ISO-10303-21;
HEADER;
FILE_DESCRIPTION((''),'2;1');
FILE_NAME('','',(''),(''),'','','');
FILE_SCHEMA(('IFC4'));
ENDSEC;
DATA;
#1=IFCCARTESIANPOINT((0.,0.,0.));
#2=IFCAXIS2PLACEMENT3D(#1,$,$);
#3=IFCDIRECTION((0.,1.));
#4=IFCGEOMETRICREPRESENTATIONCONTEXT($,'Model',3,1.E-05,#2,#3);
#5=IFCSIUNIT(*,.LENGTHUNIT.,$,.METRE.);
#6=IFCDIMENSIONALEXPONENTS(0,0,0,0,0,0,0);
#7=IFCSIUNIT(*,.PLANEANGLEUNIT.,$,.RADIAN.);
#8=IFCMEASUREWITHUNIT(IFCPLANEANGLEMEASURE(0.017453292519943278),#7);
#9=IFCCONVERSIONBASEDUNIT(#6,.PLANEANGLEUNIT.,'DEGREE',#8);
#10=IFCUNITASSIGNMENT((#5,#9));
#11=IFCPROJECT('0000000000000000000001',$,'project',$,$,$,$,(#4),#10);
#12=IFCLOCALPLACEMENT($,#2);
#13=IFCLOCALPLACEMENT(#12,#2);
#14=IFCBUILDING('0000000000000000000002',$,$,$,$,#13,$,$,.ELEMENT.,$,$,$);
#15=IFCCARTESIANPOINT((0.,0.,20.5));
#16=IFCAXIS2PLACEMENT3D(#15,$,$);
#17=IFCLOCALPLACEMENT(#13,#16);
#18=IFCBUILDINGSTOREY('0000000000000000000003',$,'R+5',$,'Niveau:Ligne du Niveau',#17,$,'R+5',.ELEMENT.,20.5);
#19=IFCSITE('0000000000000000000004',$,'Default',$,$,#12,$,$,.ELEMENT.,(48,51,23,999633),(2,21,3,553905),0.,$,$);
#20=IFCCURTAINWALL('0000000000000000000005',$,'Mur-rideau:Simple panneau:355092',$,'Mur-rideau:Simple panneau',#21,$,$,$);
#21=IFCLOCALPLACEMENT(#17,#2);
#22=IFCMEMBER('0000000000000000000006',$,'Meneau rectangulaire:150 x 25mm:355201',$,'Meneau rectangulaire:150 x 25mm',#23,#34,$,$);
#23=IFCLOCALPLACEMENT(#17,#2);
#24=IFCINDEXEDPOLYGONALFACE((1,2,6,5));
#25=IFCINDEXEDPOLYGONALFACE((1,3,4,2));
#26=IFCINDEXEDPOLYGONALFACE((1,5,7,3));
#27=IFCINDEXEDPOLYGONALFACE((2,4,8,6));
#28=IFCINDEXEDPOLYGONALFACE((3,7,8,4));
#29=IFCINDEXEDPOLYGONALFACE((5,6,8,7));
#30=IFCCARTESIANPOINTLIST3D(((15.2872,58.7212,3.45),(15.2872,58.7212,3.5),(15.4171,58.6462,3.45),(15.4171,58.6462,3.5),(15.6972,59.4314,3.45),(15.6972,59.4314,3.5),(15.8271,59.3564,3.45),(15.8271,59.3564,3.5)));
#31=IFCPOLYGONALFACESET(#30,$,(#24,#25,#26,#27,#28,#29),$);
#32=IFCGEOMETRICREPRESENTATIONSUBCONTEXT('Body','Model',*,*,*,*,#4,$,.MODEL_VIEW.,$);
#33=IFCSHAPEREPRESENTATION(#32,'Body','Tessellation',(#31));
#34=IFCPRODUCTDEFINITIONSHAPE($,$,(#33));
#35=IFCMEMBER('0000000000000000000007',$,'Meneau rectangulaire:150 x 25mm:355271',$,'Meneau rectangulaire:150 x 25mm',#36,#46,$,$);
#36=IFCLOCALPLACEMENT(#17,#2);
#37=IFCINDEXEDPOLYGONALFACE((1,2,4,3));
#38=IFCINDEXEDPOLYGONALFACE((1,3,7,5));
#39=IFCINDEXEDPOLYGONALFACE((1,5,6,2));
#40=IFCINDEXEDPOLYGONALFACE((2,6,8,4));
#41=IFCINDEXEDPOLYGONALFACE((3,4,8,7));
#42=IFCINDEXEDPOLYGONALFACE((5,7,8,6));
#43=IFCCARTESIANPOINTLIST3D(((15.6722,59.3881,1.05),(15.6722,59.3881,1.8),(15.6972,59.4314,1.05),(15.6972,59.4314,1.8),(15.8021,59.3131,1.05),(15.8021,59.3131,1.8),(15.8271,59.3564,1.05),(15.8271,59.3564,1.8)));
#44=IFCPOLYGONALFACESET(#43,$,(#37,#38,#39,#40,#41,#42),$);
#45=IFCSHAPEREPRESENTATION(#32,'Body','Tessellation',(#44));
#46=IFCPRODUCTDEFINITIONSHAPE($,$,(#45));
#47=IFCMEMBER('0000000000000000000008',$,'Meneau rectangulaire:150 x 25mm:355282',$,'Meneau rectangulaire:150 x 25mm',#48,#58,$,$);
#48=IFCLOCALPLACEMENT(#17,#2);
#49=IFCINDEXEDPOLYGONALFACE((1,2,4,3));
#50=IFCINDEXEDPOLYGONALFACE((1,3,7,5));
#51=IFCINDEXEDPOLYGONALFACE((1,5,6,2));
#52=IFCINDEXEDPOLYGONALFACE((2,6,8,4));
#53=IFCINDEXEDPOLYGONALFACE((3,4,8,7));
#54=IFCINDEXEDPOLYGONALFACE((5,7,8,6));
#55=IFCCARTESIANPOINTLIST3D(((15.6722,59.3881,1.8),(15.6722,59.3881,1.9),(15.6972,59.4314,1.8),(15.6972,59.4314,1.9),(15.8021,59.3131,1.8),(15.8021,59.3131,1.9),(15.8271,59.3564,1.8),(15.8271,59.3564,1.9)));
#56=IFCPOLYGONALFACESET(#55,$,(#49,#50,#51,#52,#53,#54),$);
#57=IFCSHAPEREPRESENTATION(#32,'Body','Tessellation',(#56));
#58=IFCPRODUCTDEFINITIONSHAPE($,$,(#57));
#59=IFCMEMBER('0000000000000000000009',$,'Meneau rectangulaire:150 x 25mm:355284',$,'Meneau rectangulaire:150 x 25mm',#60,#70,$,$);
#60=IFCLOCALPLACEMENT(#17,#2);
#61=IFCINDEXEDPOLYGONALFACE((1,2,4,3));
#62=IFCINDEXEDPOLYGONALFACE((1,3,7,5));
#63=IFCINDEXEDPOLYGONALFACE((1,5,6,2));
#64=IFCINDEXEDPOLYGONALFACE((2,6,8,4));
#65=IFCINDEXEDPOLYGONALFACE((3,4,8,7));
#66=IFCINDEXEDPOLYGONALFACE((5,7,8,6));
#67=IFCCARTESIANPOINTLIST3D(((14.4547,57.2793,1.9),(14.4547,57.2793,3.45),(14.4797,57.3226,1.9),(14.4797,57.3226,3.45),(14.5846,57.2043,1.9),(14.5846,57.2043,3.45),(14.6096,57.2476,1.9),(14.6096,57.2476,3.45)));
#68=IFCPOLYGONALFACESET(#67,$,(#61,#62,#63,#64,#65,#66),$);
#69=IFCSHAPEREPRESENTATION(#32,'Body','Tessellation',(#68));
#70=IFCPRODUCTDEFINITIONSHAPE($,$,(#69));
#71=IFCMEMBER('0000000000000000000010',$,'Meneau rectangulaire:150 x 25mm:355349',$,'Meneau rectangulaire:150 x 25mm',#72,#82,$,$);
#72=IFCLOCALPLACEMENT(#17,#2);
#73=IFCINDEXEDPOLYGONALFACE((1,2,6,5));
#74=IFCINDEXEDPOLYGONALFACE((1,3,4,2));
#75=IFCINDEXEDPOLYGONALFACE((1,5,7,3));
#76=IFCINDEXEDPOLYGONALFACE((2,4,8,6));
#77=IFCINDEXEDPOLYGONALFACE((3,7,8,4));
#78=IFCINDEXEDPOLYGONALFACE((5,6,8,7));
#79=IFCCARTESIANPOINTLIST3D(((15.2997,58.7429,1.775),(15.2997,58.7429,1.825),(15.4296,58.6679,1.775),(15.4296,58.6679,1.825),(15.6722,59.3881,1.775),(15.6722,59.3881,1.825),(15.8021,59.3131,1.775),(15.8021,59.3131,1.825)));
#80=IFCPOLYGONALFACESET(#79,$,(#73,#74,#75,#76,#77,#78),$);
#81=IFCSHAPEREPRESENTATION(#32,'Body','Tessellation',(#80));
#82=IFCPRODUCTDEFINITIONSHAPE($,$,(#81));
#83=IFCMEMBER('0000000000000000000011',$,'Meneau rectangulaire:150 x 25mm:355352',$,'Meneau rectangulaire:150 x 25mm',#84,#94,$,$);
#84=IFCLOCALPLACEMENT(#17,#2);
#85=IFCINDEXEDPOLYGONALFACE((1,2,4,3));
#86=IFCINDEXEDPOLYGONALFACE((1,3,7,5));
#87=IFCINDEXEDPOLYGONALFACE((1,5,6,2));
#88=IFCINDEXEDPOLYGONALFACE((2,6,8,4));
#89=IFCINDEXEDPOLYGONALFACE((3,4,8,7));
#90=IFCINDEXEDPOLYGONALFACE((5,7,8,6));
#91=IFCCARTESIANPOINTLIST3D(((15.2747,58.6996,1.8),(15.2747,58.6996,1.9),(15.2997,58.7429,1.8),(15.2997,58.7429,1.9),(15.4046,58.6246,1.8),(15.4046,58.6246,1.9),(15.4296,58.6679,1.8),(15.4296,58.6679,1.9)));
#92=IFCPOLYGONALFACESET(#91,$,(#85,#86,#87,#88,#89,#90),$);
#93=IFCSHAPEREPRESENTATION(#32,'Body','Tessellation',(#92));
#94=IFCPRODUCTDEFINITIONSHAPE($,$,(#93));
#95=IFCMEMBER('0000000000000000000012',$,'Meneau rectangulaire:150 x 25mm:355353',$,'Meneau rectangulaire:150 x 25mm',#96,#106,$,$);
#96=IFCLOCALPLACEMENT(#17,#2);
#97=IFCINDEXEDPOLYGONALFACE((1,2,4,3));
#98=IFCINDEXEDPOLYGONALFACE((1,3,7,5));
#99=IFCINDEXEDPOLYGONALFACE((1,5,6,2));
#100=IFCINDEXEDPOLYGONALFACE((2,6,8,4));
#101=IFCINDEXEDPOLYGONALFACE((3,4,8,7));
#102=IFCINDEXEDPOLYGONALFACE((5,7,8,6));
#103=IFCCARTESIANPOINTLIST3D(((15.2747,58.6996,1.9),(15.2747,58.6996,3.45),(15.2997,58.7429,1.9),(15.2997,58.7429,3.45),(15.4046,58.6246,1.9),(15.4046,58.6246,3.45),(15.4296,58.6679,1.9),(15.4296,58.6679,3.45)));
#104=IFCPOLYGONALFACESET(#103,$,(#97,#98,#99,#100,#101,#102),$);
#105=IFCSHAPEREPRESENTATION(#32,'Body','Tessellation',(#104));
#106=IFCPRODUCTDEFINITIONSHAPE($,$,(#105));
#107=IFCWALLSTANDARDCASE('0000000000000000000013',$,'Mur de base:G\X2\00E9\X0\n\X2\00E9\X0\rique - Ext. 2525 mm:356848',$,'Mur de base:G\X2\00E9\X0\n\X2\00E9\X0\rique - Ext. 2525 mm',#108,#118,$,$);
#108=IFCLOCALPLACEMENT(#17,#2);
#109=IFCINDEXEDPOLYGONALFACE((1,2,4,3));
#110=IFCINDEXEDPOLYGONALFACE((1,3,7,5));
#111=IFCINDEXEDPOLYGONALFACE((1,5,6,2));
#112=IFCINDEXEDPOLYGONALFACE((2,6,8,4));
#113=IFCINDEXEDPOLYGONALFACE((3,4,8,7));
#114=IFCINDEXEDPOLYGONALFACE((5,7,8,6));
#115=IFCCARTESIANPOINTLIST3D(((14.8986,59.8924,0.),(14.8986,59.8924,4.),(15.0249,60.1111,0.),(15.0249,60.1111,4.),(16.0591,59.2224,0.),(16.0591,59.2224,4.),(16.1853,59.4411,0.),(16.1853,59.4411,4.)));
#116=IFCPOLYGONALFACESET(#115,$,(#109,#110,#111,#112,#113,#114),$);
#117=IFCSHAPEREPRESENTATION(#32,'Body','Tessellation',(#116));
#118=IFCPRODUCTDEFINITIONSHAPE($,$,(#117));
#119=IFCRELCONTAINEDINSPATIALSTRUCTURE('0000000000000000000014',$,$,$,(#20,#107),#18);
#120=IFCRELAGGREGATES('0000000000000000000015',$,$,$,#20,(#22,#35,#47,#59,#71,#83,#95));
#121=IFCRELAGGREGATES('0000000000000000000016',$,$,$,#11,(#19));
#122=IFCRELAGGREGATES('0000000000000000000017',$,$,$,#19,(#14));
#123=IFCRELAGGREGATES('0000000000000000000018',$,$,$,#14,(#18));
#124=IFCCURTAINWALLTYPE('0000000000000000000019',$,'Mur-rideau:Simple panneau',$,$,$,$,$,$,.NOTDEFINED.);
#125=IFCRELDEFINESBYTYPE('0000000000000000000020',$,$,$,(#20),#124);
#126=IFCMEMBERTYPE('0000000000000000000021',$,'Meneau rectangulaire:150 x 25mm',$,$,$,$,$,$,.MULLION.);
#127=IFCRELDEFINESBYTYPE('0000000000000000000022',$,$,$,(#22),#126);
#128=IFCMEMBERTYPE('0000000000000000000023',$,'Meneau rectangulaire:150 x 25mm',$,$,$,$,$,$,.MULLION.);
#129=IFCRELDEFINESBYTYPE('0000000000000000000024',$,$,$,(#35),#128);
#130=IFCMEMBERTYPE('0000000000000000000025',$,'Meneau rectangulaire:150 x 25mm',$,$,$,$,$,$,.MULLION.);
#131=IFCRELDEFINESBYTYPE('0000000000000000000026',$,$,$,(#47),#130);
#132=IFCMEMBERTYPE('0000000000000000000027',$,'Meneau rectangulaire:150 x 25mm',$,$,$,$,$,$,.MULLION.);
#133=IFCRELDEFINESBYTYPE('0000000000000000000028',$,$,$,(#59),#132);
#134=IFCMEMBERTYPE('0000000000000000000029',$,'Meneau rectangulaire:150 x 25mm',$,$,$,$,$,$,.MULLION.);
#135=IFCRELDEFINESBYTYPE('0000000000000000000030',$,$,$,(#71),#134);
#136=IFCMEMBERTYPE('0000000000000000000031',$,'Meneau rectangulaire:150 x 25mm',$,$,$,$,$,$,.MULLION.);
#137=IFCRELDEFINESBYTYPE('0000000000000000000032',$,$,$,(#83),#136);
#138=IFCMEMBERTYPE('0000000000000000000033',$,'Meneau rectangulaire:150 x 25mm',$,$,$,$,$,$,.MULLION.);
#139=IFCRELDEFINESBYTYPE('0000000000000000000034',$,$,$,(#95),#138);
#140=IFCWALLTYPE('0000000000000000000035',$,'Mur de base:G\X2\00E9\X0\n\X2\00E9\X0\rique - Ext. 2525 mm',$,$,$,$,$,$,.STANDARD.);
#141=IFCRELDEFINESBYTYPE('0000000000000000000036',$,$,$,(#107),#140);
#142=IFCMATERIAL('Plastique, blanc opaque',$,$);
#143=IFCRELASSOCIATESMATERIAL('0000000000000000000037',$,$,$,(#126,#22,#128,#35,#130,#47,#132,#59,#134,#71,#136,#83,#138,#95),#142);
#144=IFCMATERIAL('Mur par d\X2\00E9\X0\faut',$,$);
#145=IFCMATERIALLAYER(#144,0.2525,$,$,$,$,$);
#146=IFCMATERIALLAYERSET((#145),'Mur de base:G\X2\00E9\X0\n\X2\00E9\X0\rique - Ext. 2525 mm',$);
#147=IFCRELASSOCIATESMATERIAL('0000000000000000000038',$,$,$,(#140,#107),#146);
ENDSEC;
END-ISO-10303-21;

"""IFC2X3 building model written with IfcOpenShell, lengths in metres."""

from ifc_helpers import new_model, entity, si_unit, converted_unit, direction, frame, frame_2d, origin, origin_2d_with_axis, place, context, subcontext, project, spatial, rectangle, extrude, source, transform, mapped, material, layer, layer_set, layer_usage, type_object, type_shapes, element, aggregate, save


model = new_model("IFC2X3")

# Units and contexts
model_context = context("Model", 3, precision=1e-05, world=origin(), true_north=direction((0.0, 1.0)))
body_context = subcontext(model_context, "Body", "Model", "MODEL_VIEW")
ifc_project = project(units=[si_unit("LENGTHUNIT", "METRE"), converted_unit("PLANEANGLEUNIT", "DEGREE", entity("IfcPlaneAngleMeasure", 0.017453292519943278), si_unit("PLANEANGLEUNIT", "RADIAN"), dimensions=[0, 0, 0, 0, 0, 0, 0])], contexts=[model_context])

# Site, building, storey
site_placement = place(None, origin())
site = spatial("IfcSite", under=ifc_project, at=site_placement, Name="Default", CompositionType="ELEMENT", RefLatitude=(48, 51, 23, 999633), RefLongitude=(2, 21, 3, 553905), RefElevation=0.0)
building_placement = place(site_placement, origin())
building = spatial("IfcBuilding", under=site, at=building_placement, CompositionType="ELEMENT")
storey_placement = place(building_placement, frame((0.0, 0.0, 20.5)))
storey = spatial("IfcBuildingStorey", under=building, at=storey_placement, Name="R+5", ObjectType="Niveau:Ligne du Niveau", LongName="R+5", CompositionType="ELEMENT", Elevation=20.5)

# Curtain wall
curtain_wall_type = type_object("IfcCurtainWallType", Name="Mur-rideau:Simple panneau", PredefinedType="NOTDEFINED")
ifc_material_1 = material(Name="Plastique, blanc opaque")
curtain_wall_1_placement = place(storey_placement, frame((0.0, 0.0, -20.5)))
curtain_wall_1 = element("IfcCurtainWall", 1, at=curtain_wall_1_placement, inside=storey, type_object=curtain_wall_type, Name="Mur-rideau:Simple panneau:355092", ObjectType="Mur-rideau:Simple panneau")

# Members
member_type_1 = type_object("IfcMemberType", Name="Meneau rectangulaire:150 x 25mm", PredefinedType="MULLION", material=ifc_material_1)
shared_shape_1 = source(origin(), body_context, "Body", "SweptSolid", [
    extrude(rectangle(XDim=0.05, YDim=0.15, at=frame_2d((0.0, 0.0), x_axis=(1.0, 0.0))), frame((-0.025, 0.0, -0.82), z_axis=(0.0, 0.0, 1.0), x_axis=(-1.0, 0.0, 0.0)), (0.0, 0.0, 1.0), 0.82),
])
type_shapes(member_type_1, [shared_shape_1])
member_1_placement = place(curtain_wall_1_placement, frame((15.3522, 58.6837, 24.0), z_axis=(-0.5, -0.866025, 0.0), x_axis=(0.0, 0.0, 1.0)))
member_1 = element("IfcMember", 2, at=member_1_placement, type_object=member_type_1, material=ifc_material_1, Name="Meneau rectangulaire:150 x 25mm:355201", ObjectType="Meneau rectangulaire:150 x 25mm", context=body_context, shape_type="MappedRepresentation", body=[
    mapped(shared_shape_1, transform((0.0, 0.0, 0.0), scale=1.0)),
])
member_type_2 = type_object("IfcMemberType", Name="Meneau rectangulaire:150 x 25mm", PredefinedType="MULLION", material=ifc_material_1)
shared_shape_2 = source(origin(), body_context, "Body", "SweptSolid", [
    extrude(rectangle(XDim=0.05, YDim=0.15, at=origin_2d_with_axis()), frame((-0.025, 0.0, -0.75), z_axis=(0.0, 0.0, 1.0), x_axis=(-1.0, 0.0, 0.0)), (0.0, 0.0, 1.0), 0.75),
])
type_shapes(member_type_2, [shared_shape_2])
member_2_placement = place(curtain_wall_1_placement, frame((15.7622, 59.3939, 22.3), z_axis=(0.0, 0.0, 1.0), x_axis=(0.5, 0.866025, 0.0)))
member_2 = element("IfcMember", 3, at=member_2_placement, type_object=member_type_2, material=ifc_material_1, Name="Meneau rectangulaire:150 x 25mm:355271", ObjectType="Meneau rectangulaire:150 x 25mm", context=body_context, shape_type="MappedRepresentation", body=[
    mapped(shared_shape_2, transform((0.0, 0.0, 0.0), scale=1.0)),
])
member_type_3 = type_object("IfcMemberType", Name="Meneau rectangulaire:150 x 25mm", PredefinedType="MULLION", material=ifc_material_1)
shared_shape_3 = source(origin(), body_context, "Body", "SweptSolid", [
    extrude(rectangle(XDim=0.05, YDim=0.15, at=origin_2d_with_axis()), frame((-0.025, 0.0, -0.1), z_axis=(0.0, 0.0, 1.0), x_axis=(-1.0, 0.0, 0.0)), (0.0, 0.0, 1.0), 0.1),
])
type_shapes(member_type_3, [shared_shape_3])
member_3_placement = place(curtain_wall_1_placement, frame((15.7622, 59.3939, 22.4), z_axis=(0.0, 0.0, 1.0), x_axis=(0.5, 0.866025, 0.0)))
member_3 = element("IfcMember", 4, at=member_3_placement, type_object=member_type_3, material=ifc_material_1, Name="Meneau rectangulaire:150 x 25mm:355282", ObjectType="Meneau rectangulaire:150 x 25mm", context=body_context, shape_type="MappedRepresentation", body=[
    mapped(shared_shape_3, transform((0.0, 0.0, 0.0), scale=1.0)),
])
member_type_4 = type_object("IfcMemberType", Name="Meneau rectangulaire:150 x 25mm", PredefinedType="MULLION", material=ifc_material_1)
shared_shape_4 = source(origin(), body_context, "Body", "SweptSolid", [
    extrude(rectangle(XDim=0.05, YDim=0.15, at=origin_2d_with_axis()), frame((0.0, 0.0, -1.55), z_axis=(0.0, 0.0, 1.0), x_axis=(-1.0, 0.0, 0.0)), (0.0, 0.0, 1.0), 1.55),
])
type_shapes(member_type_4, [shared_shape_4])
member_4_placement = place(curtain_wall_1_placement, frame((14.5322, 57.2634, 22.4), z_axis=(0.0, 0.0, -1.0), x_axis=(-0.5, -0.866025, 0.0)))
member_4 = element("IfcMember", 5, at=member_4_placement, type_object=member_type_4, material=ifc_material_1, Name="Meneau rectangulaire:150 x 25mm:355284", ObjectType="Meneau rectangulaire:150 x 25mm", context=body_context, shape_type="MappedRepresentation", body=[
    mapped(shared_shape_4, transform((0.0, 0.0, 0.0), scale=1.0)),
])
member_type_5 = type_object("IfcMemberType", Name="Meneau rectangulaire:150 x 25mm", PredefinedType="MULLION", material=ifc_material_1)
shared_shape_5 = source(origin(), body_context, "Body", "SweptSolid", [
    extrude(rectangle(XDim=0.05, YDim=0.15, at=origin_2d_with_axis()), frame((0.0, 0.0, -0.745), z_axis=(0.0, 0.0, 1.0), x_axis=(-1.0, 0.0, 0.0)), (0.0, 0.0, 1.0), 0.745),
])
type_shapes(member_type_5, [shared_shape_5])
member_5_placement = place(curtain_wall_1_placement, frame((15.3647, 58.7054, 22.3), z_axis=(-0.5, -0.866025, 0.0), x_axis=(0.0, 0.0, 1.0)))
member_5 = element("IfcMember", 6, at=member_5_placement, type_object=member_type_5, material=ifc_material_1, Name="Meneau rectangulaire:150 x 25mm:355349", ObjectType="Meneau rectangulaire:150 x 25mm", context=body_context, shape_type="MappedRepresentation", body=[
    mapped(shared_shape_5, transform((0.0, 0.0, 0.0), scale=1.0)),
])
member_type_6 = type_object("IfcMemberType", Name="Meneau rectangulaire:150 x 25mm", PredefinedType="MULLION", material=ifc_material_1)
shared_shape_6 = source(origin(), body_context, "Body", "SweptSolid", [
    extrude(rectangle(XDim=0.05, YDim=0.15, at=origin_2d_with_axis()), frame((0.0, 0.0, -0.1), z_axis=(0.0, 0.0, 1.0), x_axis=(-1.0, 0.0, 0.0)), (0.0, 0.0, 1.0), 0.1),
])
type_shapes(member_type_6, [shared_shape_6])
member_6_placement = place(curtain_wall_1_placement, frame((15.3522, 58.6837, 22.3), z_axis=(0.0, 0.0, -1.0), x_axis=(-0.5, -0.866025, 0.0)))
member_6 = element("IfcMember", 7, at=member_6_placement, type_object=member_type_6, material=ifc_material_1, Name="Meneau rectangulaire:150 x 25mm:355352", ObjectType="Meneau rectangulaire:150 x 25mm", context=body_context, shape_type="MappedRepresentation", body=[
    mapped(shared_shape_6, transform((0.0, 0.0, 0.0), scale=1.0)),
])
member_type_7 = type_object("IfcMemberType", Name="Meneau rectangulaire:150 x 25mm", PredefinedType="MULLION", material=ifc_material_1)
shared_shape_7 = source(origin(), body_context, "Body", "SweptSolid", [
    extrude(rectangle(XDim=0.05, YDim=0.15, at=origin_2d_with_axis()), frame((0.0, 0.0, -1.55), z_axis=(0.0, 0.0, 1.0), x_axis=(-1.0, 0.0, 0.0)), (0.0, 0.0, 1.0), 1.55),
])
type_shapes(member_type_7, [shared_shape_7])
member_7_placement = place(curtain_wall_1_placement, frame((15.3522, 58.6837, 22.4), z_axis=(0.0, 0.0, -1.0), x_axis=(-0.5, -0.866025, 0.0)))
member_7 = element("IfcMember", 8, at=member_7_placement, type_object=member_type_7, material=ifc_material_1, Name="Meneau rectangulaire:150 x 25mm:355353", ObjectType="Meneau rectangulaire:150 x 25mm", context=body_context, shape_type="MappedRepresentation", body=[
    mapped(shared_shape_7, transform((0.0, 0.0, 0.0), scale=1.0)),
])

aggregate(curtain_wall_1, [member_1, member_2, member_3, member_4, member_5, member_6, member_7])

# Wall
ifc_material_2 = material(Name="Mur par défaut")
ifc_layer_1 = layer(ifc_material_2, 0.2525)
ifc_layer_set_1 = layer_set([ifc_layer_1], Name="Mur de base:Générique - Ext. 2525 mm")
ifc_layer_usage = layer_usage(ifc_layer_set_1, "AXIS2", "NEGATIVE", 0.1263)
wall_type = type_object("IfcWallType", Name="Mur de base:Générique - Ext. 2525 mm", PredefinedType="STANDARD", material=ifc_layer_set_1)
wall_placement = place(storey_placement, frame((16.1222, 59.3318, 0.0), z_axis=(0.0, 0.0, 1.0), x_axis=(-0.866025, 0.5, 0.0)))
element("IfcWallStandardCase", 9, at=wall_placement, inside=storey, type_object=wall_type, material=ifc_layer_usage, Name="Mur de base:Générique - Ext. 2525 mm:356848", ObjectType="Mur de base:Générique - Ext. 2525 mm", context=body_context, shape_type="SweptSolid", body=[
    extrude(rectangle(XDim=1.34, YDim=0.2525, at=frame_2d((0.67, 0.0), x_axis=(-1.0, 0.0))), origin(), (0.0, 0.0, 1.0), 4.0),
])

save(model, "model.ifc")
